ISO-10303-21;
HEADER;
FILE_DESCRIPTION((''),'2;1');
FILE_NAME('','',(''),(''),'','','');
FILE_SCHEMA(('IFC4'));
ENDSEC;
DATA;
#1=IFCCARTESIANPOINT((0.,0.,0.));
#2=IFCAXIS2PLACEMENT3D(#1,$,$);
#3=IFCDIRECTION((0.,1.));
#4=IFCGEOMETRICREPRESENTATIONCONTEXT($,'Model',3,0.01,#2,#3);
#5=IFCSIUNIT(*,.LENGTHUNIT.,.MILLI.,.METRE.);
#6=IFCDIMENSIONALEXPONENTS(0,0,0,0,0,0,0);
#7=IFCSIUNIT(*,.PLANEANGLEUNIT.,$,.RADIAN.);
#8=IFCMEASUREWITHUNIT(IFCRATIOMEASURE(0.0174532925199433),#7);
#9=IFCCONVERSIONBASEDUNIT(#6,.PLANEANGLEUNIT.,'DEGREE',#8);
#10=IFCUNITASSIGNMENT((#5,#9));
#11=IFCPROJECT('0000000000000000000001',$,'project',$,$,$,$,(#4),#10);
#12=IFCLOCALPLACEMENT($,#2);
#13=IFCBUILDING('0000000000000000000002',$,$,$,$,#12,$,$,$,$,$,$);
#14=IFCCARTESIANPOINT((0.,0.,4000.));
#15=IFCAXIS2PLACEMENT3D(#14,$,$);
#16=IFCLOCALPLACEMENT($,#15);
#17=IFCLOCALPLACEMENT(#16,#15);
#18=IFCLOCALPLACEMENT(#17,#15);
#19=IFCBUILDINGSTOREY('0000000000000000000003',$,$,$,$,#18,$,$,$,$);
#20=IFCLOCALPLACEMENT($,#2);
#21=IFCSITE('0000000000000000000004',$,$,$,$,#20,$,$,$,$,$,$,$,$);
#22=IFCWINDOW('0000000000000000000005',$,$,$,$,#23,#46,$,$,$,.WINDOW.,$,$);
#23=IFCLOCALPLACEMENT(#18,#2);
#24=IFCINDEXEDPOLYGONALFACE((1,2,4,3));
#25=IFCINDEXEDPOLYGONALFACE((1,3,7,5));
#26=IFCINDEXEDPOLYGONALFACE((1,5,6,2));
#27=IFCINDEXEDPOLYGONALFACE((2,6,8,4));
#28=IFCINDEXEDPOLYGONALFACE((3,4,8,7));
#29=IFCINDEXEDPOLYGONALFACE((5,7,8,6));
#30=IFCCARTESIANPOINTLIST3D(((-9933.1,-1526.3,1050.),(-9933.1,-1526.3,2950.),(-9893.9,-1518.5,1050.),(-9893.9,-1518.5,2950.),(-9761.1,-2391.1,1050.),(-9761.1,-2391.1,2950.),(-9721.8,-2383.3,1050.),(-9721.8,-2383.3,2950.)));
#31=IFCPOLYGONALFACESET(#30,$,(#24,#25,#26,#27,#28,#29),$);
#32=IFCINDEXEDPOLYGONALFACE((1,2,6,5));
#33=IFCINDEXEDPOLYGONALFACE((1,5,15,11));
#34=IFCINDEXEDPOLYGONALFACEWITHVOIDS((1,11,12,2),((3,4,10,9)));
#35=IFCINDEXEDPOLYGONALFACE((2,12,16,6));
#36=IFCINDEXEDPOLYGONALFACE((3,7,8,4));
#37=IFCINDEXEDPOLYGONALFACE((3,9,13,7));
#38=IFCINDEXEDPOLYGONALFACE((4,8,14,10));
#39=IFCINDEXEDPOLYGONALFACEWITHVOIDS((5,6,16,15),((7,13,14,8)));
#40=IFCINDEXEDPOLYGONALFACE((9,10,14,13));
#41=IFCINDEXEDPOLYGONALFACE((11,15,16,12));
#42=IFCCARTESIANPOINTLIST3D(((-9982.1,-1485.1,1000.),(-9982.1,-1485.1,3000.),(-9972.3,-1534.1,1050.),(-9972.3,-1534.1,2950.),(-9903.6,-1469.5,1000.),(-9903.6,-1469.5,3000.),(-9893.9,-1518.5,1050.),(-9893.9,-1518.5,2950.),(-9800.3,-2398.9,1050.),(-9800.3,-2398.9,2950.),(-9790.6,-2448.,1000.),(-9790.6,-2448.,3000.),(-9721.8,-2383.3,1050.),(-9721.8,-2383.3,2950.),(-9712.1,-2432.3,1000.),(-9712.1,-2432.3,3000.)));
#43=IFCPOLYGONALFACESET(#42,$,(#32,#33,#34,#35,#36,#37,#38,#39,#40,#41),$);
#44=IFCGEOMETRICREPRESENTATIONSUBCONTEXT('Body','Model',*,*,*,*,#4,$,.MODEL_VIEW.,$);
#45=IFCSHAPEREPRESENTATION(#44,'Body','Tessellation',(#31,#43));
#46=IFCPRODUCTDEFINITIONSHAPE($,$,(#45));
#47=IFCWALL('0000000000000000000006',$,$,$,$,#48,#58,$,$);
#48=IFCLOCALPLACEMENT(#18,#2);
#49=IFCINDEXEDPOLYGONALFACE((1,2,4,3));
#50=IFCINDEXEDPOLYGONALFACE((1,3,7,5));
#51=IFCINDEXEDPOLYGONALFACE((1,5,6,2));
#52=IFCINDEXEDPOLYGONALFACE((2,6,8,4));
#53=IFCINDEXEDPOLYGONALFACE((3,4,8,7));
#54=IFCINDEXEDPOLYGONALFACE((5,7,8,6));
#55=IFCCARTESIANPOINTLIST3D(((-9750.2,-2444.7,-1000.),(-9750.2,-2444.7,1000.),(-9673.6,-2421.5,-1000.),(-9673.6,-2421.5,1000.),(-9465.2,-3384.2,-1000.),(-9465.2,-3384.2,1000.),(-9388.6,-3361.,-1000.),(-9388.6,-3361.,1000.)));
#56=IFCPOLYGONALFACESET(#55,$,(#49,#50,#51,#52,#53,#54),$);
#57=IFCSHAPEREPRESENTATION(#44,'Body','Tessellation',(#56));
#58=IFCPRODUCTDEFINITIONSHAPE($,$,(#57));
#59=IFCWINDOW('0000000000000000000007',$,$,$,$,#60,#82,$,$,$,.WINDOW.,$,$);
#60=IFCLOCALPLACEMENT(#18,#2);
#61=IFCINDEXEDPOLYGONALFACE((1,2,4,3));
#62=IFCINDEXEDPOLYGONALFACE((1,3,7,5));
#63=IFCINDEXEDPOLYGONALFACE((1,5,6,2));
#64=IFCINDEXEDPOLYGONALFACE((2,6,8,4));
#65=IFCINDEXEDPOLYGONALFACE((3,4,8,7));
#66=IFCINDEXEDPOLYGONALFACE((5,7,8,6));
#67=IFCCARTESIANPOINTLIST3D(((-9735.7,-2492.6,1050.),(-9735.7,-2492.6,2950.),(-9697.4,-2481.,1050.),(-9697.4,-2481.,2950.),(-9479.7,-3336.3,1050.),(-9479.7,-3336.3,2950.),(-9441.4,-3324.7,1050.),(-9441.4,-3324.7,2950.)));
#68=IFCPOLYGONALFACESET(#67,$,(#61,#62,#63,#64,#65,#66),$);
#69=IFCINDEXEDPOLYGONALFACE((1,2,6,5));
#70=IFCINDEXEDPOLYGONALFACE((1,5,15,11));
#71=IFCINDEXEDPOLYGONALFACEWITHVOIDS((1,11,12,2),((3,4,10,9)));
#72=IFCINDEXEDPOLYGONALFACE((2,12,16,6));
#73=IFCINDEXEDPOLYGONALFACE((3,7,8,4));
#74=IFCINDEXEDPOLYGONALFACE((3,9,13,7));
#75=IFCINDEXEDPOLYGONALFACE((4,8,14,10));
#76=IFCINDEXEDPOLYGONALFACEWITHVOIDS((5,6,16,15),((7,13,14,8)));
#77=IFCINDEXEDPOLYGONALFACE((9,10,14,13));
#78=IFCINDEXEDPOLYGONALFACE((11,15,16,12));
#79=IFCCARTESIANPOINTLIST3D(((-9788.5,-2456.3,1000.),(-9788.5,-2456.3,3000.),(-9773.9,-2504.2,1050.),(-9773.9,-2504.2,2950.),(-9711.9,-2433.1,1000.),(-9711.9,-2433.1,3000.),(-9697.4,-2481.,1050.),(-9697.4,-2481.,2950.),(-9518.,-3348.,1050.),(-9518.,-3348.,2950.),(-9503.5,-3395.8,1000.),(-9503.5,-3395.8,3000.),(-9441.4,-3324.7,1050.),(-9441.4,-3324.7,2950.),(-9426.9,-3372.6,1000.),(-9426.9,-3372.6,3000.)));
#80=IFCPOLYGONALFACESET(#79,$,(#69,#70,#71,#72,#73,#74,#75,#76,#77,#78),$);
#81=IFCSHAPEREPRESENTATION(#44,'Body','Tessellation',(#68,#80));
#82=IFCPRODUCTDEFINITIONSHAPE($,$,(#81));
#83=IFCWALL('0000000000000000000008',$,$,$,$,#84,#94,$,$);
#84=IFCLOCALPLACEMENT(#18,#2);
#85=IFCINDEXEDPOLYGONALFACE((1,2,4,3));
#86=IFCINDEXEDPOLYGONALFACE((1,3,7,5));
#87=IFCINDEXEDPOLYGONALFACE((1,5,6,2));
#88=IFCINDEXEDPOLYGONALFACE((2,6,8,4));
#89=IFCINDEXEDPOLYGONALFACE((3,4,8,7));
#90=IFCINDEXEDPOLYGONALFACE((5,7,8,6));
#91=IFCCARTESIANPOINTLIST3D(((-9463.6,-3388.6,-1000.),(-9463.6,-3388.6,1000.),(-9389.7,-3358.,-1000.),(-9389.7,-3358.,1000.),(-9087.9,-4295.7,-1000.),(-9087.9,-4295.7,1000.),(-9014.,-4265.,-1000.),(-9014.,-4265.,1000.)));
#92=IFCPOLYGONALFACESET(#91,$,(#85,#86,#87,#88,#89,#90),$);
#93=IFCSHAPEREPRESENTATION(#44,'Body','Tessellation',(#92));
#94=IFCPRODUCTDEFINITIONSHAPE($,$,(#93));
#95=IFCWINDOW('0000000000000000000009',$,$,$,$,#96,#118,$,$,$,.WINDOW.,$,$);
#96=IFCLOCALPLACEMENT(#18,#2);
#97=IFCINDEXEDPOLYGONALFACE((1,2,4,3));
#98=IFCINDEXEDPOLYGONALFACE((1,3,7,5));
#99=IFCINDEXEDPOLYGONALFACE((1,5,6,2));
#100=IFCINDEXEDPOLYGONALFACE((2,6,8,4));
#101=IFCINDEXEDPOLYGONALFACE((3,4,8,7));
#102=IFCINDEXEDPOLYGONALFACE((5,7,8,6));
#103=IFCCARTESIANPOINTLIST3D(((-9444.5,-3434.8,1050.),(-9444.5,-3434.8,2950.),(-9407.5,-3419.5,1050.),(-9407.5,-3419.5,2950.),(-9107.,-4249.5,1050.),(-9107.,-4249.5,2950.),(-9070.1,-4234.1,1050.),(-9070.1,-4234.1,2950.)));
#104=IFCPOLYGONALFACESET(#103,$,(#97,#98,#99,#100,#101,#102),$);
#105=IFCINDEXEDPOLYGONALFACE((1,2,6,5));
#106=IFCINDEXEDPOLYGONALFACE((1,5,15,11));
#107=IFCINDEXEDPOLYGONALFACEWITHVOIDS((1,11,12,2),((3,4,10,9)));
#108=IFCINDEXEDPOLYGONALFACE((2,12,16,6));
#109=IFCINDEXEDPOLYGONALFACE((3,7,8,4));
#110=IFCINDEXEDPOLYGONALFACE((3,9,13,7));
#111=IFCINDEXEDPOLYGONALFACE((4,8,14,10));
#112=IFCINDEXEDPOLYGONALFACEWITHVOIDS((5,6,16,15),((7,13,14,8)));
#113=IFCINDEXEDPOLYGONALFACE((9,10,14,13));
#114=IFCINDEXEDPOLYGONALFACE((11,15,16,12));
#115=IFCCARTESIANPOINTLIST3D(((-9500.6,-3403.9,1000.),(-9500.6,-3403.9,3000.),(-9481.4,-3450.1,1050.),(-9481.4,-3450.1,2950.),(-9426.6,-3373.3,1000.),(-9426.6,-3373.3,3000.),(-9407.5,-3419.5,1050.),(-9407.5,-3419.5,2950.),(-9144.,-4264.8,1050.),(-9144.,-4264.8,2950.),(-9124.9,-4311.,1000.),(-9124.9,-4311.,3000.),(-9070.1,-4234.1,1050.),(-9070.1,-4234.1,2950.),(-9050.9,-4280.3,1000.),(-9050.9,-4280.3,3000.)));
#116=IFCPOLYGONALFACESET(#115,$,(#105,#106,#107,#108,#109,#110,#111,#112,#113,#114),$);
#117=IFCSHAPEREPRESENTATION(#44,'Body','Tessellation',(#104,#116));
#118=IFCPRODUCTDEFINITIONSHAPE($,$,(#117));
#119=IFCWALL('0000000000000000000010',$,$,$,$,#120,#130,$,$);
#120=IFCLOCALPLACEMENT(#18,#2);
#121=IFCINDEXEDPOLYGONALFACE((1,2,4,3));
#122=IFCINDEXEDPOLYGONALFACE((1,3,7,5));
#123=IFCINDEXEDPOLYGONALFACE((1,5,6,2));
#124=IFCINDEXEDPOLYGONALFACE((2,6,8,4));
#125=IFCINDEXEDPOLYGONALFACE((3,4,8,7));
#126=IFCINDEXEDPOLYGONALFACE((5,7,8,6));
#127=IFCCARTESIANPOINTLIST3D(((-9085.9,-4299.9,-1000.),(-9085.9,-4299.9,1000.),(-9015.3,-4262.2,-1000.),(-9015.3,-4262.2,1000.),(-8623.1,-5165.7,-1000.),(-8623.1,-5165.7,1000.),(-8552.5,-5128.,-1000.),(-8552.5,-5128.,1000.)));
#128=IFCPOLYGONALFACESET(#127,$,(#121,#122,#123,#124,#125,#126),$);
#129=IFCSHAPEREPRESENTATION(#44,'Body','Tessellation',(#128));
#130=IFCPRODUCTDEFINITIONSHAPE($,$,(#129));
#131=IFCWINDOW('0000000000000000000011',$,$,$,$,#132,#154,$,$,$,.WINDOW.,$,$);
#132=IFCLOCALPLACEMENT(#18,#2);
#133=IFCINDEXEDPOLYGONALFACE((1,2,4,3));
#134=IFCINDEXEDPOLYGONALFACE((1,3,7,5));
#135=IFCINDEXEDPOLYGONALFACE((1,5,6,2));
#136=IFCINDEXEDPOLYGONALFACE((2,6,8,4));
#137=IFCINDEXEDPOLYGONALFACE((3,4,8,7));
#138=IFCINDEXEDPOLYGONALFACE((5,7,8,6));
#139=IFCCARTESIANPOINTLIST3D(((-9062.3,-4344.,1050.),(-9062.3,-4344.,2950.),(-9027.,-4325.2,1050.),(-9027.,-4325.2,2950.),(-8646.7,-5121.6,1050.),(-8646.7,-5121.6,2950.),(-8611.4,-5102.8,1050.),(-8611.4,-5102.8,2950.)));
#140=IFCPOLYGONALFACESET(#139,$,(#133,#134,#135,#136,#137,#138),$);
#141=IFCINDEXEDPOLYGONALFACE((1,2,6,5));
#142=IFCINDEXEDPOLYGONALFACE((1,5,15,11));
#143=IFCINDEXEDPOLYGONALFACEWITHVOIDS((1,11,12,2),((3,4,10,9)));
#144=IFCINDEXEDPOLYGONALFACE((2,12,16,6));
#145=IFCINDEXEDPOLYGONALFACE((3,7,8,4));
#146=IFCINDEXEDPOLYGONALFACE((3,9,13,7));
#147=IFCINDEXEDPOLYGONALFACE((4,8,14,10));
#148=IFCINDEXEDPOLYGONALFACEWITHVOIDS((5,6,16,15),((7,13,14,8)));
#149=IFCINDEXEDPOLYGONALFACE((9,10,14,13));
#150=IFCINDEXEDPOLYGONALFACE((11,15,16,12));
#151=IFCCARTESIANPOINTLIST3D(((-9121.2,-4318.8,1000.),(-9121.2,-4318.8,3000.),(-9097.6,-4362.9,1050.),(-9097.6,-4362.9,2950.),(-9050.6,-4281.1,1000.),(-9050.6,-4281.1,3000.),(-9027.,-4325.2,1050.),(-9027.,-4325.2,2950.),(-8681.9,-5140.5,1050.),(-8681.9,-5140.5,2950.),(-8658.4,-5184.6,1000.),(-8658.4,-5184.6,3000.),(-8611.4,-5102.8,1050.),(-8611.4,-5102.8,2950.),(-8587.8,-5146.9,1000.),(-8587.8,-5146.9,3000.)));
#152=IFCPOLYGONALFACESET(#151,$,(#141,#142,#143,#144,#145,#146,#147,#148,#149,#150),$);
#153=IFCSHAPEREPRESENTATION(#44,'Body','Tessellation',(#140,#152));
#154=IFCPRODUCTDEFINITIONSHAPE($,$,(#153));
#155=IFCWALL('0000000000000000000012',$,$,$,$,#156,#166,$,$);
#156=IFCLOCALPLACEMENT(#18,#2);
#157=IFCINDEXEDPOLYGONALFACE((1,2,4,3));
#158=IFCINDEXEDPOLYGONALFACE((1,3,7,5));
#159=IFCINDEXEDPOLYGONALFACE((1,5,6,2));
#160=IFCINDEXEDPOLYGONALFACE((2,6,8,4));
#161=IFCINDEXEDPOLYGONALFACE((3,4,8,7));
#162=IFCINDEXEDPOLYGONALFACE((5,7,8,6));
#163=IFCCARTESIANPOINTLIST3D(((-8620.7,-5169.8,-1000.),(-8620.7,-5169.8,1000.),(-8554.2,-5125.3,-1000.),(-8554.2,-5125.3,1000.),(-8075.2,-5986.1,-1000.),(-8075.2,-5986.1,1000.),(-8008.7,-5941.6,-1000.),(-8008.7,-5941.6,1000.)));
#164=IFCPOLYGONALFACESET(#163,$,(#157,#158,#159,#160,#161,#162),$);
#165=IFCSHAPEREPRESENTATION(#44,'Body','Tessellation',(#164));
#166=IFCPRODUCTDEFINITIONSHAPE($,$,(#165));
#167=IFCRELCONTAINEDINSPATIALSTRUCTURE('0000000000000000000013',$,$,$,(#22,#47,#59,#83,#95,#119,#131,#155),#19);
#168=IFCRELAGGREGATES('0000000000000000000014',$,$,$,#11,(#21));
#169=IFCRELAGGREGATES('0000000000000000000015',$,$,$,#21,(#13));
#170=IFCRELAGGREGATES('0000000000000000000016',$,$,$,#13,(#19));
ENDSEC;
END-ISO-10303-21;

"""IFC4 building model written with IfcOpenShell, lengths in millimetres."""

from ifc_helpers import new_model, entity, si_unit, converted_unit, direction, frame, origin, origin_2d, place, context, subcontext, project, spatial, rectangle, extrude, element, save


model = new_model("IFC4")

# Units and contexts
model_context = context("Model", 3, precision=0.01, world=origin(), true_north=direction((0.0, 1.0)))
body_context = subcontext(model_context, "Body", "Model", "MODEL_VIEW")
ifc_project = project(units=[si_unit("LENGTHUNIT", "METRE", prefix="MILLI"), converted_unit("PLANEANGLEUNIT", "DEGREE", entity("IfcRatioMeasure", 0.0174532925199433), si_unit("PLANEANGLEUNIT", "RADIAN"), dimensions=[0, 0, 0, 0, 0, 0, 0])], contexts=[model_context])

# Site, building, storey
site_placement = place(None, origin())
site = spatial("IfcSite", under=ifc_project, at=site_placement)
building_placement = place(None, origin())
building = spatial("IfcBuilding", under=site, at=building_placement)
placement_1 = place(None, frame((0.0, 0.0, 4000.0)))
placement_2 = place(placement_1, frame((0.0, 0.0, 4000.0)))
storey_placement = place(placement_2, frame((0.0, 0.0, 4000.0)))
storey = spatial("IfcBuildingStorey", under=building, at=storey_placement)

# Shared definitions
cartesian_point_1 = entity("IfcCartesianPoint", [-440.9, -950.0])
shared_polyline = entity("IfcPolyline", [cartesian_point_1, entity("IfcCartesianPoint", [-440.9, 950.0]), entity("IfcCartesianPoint", [-440.9, 950.0]), entity("IfcCartesianPoint", [440.9, 950.0]), entity("IfcCartesianPoint", [440.9, 950.0]), entity("IfcCartesianPoint", [440.9, -950.0]), entity("IfcCartesianPoint", [440.9, -950.0]), entity("IfcCartesianPoint", [-440.9, -950.0]), cartesian_point_1])

# Window
window_1_placement = place(storey_placement, frame((-9807.9, -1950.9, 2000.0), z_axis=(0.0, 0.0, 1.0), x_axis=(1950.902524, -9807.852943, 0.0)))
cartesian_point_2 = entity("IfcCartesianPoint", [-490.9, -1000.0])
element("IfcWindow", 1, at=window_1_placement, inside=storey, PredefinedType="WINDOW", context=body_context, shape_type="SweptSolid", body=[
    entity("IfcExtrudedAreaSolid", entity("IfcArbitraryClosedProfileDef", "AREA", None, shared_polyline), entity("IfcAxis2Placement3D", entity("IfcCartesianPoint", [0.0, 0.0, 0.0]), entity("IfcDirection", [0.0, -1.0, 0.0]), entity("IfcDirection", [1.0, 0.0, 0.0])), entity("IfcDirection", [0.0, 0.0, 1.0]), 40.0),
    entity("IfcExtrudedAreaSolid", entity("IfcArbitraryProfileDefWithVoids", "AREA", None, entity("IfcPolyline", [cartesian_point_2, entity("IfcCartesianPoint", [-490.9, 1000.0]), entity("IfcCartesianPoint", [-490.9, 1000.0]), entity("IfcCartesianPoint", [490.9, 1000.0]), entity("IfcCartesianPoint", [490.9, 1000.0]), entity("IfcCartesianPoint", [490.9, -1000.0]), entity("IfcCartesianPoint", [490.9, -1000.0]), entity("IfcCartesianPoint", [-490.9, -1000.0]), cartesian_point_2]), [shared_polyline]), entity("IfcAxis2Placement3D", entity("IfcCartesianPoint", [0.0, 0.0, 0.0]), entity("IfcDirection", [0.0, -1.0, 0.0]), entity("IfcDirection", [1.0, 0.0, 0.0])), entity("IfcDirection", [0.0, 0.0, 1.0]), 80.0),
])

# Wall
wall_1_placement = place(storey_placement, frame((-9569.4, -2902.8, -1000.0), z_axis=(0.0, 0.0, 1.0), x_axis=(2902.846475, -9569.403447, 0.0)))
element("IfcWall", 2, at=wall_1_placement, inside=storey, context=body_context, shape_type="SweptSolid", body=[
    extrude(rectangle(XDim=981.7, YDim=80.0, at=origin_2d()), origin(), (0.0, 0.0, 1.0), 2000.0),
])

# Window
window_2_placement = place(storey_placement, frame((-9569.4, -2902.8, 2000.0), z_axis=(0.0, 0.0, 1.0), x_axis=(2902.846475, -9569.403447, 0.0)))
cartesian_point_3 = entity("IfcCartesianPoint", [-490.9, -1000.0])
element("IfcWindow", 3, at=window_2_placement, inside=storey, PredefinedType="WINDOW", context=body_context, shape_type="SweptSolid", body=[
    entity("IfcExtrudedAreaSolid", entity("IfcArbitraryClosedProfileDef", "AREA", None, shared_polyline), entity("IfcAxis2Placement3D", entity("IfcCartesianPoint", [0.0, 0.0, 0.0]), entity("IfcDirection", [0.0, -1.0, 0.0]), entity("IfcDirection", [1.0, 0.0, 0.0])), entity("IfcDirection", [0.0, 0.0, 1.0]), 40.0),
    entity("IfcExtrudedAreaSolid", entity("IfcArbitraryProfileDefWithVoids", "AREA", None, entity("IfcPolyline", [cartesian_point_3, entity("IfcCartesianPoint", [-490.9, 1000.0]), entity("IfcCartesianPoint", [-490.9, 1000.0]), entity("IfcCartesianPoint", [490.9, 1000.0]), entity("IfcCartesianPoint", [490.9, 1000.0]), entity("IfcCartesianPoint", [490.9, -1000.0]), entity("IfcCartesianPoint", [490.9, -1000.0]), entity("IfcCartesianPoint", [-490.9, -1000.0]), cartesian_point_3]), [shared_polyline]), entity("IfcAxis2Placement3D", entity("IfcCartesianPoint", [0.0, 0.0, 0.0]), entity("IfcDirection", [0.0, -1.0, 0.0]), entity("IfcDirection", [1.0, 0.0, 0.0])), entity("IfcDirection", [0.0, 0.0, 1.0]), 80.0),
])

# Wall
wall_2_placement = place(storey_placement, frame((-9238.8, -3826.8, -1000.0), z_axis=(0.0, 0.0, 1.0), x_axis=(3826.834406, -9238.795291, 0.0)))
element("IfcWall", 4, at=wall_2_placement, inside=storey, context=body_context, shape_type="SweptSolid", body=[
    extrude(rectangle(XDim=981.7, YDim=80.0, at=origin_2d()), origin(), (0.0, 0.0, 1.0), 2000.0),
])

# Window
window_3_placement = place(storey_placement, frame((-9238.8, -3826.8, 2000.0), z_axis=(0.0, 0.0, 1.0), x_axis=(3826.834406, -9238.795291, 0.0)))
cartesian_point_4 = entity("IfcCartesianPoint", [-490.9, -1000.0])
element("IfcWindow", 5, at=window_3_placement, inside=storey, PredefinedType="WINDOW", context=body_context, shape_type="SweptSolid", body=[
    entity("IfcExtrudedAreaSolid", entity("IfcArbitraryClosedProfileDef", "AREA", None, shared_polyline), entity("IfcAxis2Placement3D", entity("IfcCartesianPoint", [0.0, 0.0, 0.0]), entity("IfcDirection", [0.0, -1.0, 0.0]), entity("IfcDirection", [1.0, 0.0, 0.0])), entity("IfcDirection", [0.0, 0.0, 1.0]), 40.0),
    entity("IfcExtrudedAreaSolid", entity("IfcArbitraryProfileDefWithVoids", "AREA", None, entity("IfcPolyline", [cartesian_point_4, entity("IfcCartesianPoint", [-490.9, 1000.0]), entity("IfcCartesianPoint", [-490.9, 1000.0]), entity("IfcCartesianPoint", [490.9, 1000.0]), entity("IfcCartesianPoint", [490.9, 1000.0]), entity("IfcCartesianPoint", [490.9, -1000.0]), entity("IfcCartesianPoint", [490.9, -1000.0]), entity("IfcCartesianPoint", [-490.9, -1000.0]), cartesian_point_4]), [shared_polyline]), entity("IfcAxis2Placement3D", entity("IfcCartesianPoint", [0.0, 0.0, 0.0]), entity("IfcDirection", [0.0, -1.0, 0.0]), entity("IfcDirection", [1.0, 0.0, 0.0])), entity("IfcDirection", [0.0, 0.0, 1.0]), 80.0),
])

# Wall
wall_3_placement = place(storey_placement, frame((-8819.2, -4714.0, -1000.0), z_axis=(0.0, 0.0, 1.0), x_axis=(4713.9678, -8819.212413, 0.0)))
element("IfcWall", 6, at=wall_3_placement, inside=storey, context=body_context, shape_type="SweptSolid", body=[
    extrude(rectangle(XDim=981.7, YDim=80.0, at=origin_2d()), origin(), (0.0, 0.0, 1.0), 2000.0),
])

# Window
window_4_placement = place(storey_placement, frame((-8819.2, -4714.0, 2000.0), z_axis=(0.0, 0.0, 1.0), x_axis=(4713.9678, -8819.212413, 0.0)))
cartesian_point_5 = entity("IfcCartesianPoint", [-490.9, -1000.0])
element("IfcWindow", 7, at=window_4_placement, inside=storey, PredefinedType="WINDOW", context=body_context, shape_type="SweptSolid", body=[
    entity("IfcExtrudedAreaSolid", entity("IfcArbitraryClosedProfileDef", "AREA", None, shared_polyline), entity("IfcAxis2Placement3D", entity("IfcCartesianPoint", [0.0, 0.0, 0.0]), entity("IfcDirection", [0.0, -1.0, 0.0]), entity("IfcDirection", [1.0, 0.0, 0.0])), entity("IfcDirection", [0.0, 0.0, 1.0]), 40.0),
    entity("IfcExtrudedAreaSolid", entity("IfcArbitraryProfileDefWithVoids", "AREA", None, entity("IfcPolyline", [cartesian_point_5, entity("IfcCartesianPoint", [-490.9, 1000.0]), entity("IfcCartesianPoint", [-490.9, 1000.0]), entity("IfcCartesianPoint", [490.9, 1000.0]), entity("IfcCartesianPoint", [490.9, 1000.0]), entity("IfcCartesianPoint", [490.9, -1000.0]), entity("IfcCartesianPoint", [490.9, -1000.0]), entity("IfcCartesianPoint", [-490.9, -1000.0]), cartesian_point_5]), [shared_polyline]), entity("IfcAxis2Placement3D", entity("IfcCartesianPoint", [0.0, 0.0, 0.0]), entity("IfcDirection", [0.0, -1.0, 0.0]), entity("IfcDirection", [1.0, 0.0, 0.0])), entity("IfcDirection", [0.0, 0.0, 1.0]), 80.0),
])

# Wall
wall_4_placement = place(storey_placement, frame((-8314.7, -5555.7, -1000.0), z_axis=(0.0, 0.0, 1.0), x_axis=(5555.703069, -8314.695629, 0.0)))
element("IfcWall", 8, at=wall_4_placement, inside=storey, context=body_context, shape_type="SweptSolid", body=[
    extrude(rectangle(XDim=981.7, YDim=80.0, at=origin_2d()), origin(), (0.0, 0.0, 1.0), 2000.0),
])

save(model, "model.ifc")
